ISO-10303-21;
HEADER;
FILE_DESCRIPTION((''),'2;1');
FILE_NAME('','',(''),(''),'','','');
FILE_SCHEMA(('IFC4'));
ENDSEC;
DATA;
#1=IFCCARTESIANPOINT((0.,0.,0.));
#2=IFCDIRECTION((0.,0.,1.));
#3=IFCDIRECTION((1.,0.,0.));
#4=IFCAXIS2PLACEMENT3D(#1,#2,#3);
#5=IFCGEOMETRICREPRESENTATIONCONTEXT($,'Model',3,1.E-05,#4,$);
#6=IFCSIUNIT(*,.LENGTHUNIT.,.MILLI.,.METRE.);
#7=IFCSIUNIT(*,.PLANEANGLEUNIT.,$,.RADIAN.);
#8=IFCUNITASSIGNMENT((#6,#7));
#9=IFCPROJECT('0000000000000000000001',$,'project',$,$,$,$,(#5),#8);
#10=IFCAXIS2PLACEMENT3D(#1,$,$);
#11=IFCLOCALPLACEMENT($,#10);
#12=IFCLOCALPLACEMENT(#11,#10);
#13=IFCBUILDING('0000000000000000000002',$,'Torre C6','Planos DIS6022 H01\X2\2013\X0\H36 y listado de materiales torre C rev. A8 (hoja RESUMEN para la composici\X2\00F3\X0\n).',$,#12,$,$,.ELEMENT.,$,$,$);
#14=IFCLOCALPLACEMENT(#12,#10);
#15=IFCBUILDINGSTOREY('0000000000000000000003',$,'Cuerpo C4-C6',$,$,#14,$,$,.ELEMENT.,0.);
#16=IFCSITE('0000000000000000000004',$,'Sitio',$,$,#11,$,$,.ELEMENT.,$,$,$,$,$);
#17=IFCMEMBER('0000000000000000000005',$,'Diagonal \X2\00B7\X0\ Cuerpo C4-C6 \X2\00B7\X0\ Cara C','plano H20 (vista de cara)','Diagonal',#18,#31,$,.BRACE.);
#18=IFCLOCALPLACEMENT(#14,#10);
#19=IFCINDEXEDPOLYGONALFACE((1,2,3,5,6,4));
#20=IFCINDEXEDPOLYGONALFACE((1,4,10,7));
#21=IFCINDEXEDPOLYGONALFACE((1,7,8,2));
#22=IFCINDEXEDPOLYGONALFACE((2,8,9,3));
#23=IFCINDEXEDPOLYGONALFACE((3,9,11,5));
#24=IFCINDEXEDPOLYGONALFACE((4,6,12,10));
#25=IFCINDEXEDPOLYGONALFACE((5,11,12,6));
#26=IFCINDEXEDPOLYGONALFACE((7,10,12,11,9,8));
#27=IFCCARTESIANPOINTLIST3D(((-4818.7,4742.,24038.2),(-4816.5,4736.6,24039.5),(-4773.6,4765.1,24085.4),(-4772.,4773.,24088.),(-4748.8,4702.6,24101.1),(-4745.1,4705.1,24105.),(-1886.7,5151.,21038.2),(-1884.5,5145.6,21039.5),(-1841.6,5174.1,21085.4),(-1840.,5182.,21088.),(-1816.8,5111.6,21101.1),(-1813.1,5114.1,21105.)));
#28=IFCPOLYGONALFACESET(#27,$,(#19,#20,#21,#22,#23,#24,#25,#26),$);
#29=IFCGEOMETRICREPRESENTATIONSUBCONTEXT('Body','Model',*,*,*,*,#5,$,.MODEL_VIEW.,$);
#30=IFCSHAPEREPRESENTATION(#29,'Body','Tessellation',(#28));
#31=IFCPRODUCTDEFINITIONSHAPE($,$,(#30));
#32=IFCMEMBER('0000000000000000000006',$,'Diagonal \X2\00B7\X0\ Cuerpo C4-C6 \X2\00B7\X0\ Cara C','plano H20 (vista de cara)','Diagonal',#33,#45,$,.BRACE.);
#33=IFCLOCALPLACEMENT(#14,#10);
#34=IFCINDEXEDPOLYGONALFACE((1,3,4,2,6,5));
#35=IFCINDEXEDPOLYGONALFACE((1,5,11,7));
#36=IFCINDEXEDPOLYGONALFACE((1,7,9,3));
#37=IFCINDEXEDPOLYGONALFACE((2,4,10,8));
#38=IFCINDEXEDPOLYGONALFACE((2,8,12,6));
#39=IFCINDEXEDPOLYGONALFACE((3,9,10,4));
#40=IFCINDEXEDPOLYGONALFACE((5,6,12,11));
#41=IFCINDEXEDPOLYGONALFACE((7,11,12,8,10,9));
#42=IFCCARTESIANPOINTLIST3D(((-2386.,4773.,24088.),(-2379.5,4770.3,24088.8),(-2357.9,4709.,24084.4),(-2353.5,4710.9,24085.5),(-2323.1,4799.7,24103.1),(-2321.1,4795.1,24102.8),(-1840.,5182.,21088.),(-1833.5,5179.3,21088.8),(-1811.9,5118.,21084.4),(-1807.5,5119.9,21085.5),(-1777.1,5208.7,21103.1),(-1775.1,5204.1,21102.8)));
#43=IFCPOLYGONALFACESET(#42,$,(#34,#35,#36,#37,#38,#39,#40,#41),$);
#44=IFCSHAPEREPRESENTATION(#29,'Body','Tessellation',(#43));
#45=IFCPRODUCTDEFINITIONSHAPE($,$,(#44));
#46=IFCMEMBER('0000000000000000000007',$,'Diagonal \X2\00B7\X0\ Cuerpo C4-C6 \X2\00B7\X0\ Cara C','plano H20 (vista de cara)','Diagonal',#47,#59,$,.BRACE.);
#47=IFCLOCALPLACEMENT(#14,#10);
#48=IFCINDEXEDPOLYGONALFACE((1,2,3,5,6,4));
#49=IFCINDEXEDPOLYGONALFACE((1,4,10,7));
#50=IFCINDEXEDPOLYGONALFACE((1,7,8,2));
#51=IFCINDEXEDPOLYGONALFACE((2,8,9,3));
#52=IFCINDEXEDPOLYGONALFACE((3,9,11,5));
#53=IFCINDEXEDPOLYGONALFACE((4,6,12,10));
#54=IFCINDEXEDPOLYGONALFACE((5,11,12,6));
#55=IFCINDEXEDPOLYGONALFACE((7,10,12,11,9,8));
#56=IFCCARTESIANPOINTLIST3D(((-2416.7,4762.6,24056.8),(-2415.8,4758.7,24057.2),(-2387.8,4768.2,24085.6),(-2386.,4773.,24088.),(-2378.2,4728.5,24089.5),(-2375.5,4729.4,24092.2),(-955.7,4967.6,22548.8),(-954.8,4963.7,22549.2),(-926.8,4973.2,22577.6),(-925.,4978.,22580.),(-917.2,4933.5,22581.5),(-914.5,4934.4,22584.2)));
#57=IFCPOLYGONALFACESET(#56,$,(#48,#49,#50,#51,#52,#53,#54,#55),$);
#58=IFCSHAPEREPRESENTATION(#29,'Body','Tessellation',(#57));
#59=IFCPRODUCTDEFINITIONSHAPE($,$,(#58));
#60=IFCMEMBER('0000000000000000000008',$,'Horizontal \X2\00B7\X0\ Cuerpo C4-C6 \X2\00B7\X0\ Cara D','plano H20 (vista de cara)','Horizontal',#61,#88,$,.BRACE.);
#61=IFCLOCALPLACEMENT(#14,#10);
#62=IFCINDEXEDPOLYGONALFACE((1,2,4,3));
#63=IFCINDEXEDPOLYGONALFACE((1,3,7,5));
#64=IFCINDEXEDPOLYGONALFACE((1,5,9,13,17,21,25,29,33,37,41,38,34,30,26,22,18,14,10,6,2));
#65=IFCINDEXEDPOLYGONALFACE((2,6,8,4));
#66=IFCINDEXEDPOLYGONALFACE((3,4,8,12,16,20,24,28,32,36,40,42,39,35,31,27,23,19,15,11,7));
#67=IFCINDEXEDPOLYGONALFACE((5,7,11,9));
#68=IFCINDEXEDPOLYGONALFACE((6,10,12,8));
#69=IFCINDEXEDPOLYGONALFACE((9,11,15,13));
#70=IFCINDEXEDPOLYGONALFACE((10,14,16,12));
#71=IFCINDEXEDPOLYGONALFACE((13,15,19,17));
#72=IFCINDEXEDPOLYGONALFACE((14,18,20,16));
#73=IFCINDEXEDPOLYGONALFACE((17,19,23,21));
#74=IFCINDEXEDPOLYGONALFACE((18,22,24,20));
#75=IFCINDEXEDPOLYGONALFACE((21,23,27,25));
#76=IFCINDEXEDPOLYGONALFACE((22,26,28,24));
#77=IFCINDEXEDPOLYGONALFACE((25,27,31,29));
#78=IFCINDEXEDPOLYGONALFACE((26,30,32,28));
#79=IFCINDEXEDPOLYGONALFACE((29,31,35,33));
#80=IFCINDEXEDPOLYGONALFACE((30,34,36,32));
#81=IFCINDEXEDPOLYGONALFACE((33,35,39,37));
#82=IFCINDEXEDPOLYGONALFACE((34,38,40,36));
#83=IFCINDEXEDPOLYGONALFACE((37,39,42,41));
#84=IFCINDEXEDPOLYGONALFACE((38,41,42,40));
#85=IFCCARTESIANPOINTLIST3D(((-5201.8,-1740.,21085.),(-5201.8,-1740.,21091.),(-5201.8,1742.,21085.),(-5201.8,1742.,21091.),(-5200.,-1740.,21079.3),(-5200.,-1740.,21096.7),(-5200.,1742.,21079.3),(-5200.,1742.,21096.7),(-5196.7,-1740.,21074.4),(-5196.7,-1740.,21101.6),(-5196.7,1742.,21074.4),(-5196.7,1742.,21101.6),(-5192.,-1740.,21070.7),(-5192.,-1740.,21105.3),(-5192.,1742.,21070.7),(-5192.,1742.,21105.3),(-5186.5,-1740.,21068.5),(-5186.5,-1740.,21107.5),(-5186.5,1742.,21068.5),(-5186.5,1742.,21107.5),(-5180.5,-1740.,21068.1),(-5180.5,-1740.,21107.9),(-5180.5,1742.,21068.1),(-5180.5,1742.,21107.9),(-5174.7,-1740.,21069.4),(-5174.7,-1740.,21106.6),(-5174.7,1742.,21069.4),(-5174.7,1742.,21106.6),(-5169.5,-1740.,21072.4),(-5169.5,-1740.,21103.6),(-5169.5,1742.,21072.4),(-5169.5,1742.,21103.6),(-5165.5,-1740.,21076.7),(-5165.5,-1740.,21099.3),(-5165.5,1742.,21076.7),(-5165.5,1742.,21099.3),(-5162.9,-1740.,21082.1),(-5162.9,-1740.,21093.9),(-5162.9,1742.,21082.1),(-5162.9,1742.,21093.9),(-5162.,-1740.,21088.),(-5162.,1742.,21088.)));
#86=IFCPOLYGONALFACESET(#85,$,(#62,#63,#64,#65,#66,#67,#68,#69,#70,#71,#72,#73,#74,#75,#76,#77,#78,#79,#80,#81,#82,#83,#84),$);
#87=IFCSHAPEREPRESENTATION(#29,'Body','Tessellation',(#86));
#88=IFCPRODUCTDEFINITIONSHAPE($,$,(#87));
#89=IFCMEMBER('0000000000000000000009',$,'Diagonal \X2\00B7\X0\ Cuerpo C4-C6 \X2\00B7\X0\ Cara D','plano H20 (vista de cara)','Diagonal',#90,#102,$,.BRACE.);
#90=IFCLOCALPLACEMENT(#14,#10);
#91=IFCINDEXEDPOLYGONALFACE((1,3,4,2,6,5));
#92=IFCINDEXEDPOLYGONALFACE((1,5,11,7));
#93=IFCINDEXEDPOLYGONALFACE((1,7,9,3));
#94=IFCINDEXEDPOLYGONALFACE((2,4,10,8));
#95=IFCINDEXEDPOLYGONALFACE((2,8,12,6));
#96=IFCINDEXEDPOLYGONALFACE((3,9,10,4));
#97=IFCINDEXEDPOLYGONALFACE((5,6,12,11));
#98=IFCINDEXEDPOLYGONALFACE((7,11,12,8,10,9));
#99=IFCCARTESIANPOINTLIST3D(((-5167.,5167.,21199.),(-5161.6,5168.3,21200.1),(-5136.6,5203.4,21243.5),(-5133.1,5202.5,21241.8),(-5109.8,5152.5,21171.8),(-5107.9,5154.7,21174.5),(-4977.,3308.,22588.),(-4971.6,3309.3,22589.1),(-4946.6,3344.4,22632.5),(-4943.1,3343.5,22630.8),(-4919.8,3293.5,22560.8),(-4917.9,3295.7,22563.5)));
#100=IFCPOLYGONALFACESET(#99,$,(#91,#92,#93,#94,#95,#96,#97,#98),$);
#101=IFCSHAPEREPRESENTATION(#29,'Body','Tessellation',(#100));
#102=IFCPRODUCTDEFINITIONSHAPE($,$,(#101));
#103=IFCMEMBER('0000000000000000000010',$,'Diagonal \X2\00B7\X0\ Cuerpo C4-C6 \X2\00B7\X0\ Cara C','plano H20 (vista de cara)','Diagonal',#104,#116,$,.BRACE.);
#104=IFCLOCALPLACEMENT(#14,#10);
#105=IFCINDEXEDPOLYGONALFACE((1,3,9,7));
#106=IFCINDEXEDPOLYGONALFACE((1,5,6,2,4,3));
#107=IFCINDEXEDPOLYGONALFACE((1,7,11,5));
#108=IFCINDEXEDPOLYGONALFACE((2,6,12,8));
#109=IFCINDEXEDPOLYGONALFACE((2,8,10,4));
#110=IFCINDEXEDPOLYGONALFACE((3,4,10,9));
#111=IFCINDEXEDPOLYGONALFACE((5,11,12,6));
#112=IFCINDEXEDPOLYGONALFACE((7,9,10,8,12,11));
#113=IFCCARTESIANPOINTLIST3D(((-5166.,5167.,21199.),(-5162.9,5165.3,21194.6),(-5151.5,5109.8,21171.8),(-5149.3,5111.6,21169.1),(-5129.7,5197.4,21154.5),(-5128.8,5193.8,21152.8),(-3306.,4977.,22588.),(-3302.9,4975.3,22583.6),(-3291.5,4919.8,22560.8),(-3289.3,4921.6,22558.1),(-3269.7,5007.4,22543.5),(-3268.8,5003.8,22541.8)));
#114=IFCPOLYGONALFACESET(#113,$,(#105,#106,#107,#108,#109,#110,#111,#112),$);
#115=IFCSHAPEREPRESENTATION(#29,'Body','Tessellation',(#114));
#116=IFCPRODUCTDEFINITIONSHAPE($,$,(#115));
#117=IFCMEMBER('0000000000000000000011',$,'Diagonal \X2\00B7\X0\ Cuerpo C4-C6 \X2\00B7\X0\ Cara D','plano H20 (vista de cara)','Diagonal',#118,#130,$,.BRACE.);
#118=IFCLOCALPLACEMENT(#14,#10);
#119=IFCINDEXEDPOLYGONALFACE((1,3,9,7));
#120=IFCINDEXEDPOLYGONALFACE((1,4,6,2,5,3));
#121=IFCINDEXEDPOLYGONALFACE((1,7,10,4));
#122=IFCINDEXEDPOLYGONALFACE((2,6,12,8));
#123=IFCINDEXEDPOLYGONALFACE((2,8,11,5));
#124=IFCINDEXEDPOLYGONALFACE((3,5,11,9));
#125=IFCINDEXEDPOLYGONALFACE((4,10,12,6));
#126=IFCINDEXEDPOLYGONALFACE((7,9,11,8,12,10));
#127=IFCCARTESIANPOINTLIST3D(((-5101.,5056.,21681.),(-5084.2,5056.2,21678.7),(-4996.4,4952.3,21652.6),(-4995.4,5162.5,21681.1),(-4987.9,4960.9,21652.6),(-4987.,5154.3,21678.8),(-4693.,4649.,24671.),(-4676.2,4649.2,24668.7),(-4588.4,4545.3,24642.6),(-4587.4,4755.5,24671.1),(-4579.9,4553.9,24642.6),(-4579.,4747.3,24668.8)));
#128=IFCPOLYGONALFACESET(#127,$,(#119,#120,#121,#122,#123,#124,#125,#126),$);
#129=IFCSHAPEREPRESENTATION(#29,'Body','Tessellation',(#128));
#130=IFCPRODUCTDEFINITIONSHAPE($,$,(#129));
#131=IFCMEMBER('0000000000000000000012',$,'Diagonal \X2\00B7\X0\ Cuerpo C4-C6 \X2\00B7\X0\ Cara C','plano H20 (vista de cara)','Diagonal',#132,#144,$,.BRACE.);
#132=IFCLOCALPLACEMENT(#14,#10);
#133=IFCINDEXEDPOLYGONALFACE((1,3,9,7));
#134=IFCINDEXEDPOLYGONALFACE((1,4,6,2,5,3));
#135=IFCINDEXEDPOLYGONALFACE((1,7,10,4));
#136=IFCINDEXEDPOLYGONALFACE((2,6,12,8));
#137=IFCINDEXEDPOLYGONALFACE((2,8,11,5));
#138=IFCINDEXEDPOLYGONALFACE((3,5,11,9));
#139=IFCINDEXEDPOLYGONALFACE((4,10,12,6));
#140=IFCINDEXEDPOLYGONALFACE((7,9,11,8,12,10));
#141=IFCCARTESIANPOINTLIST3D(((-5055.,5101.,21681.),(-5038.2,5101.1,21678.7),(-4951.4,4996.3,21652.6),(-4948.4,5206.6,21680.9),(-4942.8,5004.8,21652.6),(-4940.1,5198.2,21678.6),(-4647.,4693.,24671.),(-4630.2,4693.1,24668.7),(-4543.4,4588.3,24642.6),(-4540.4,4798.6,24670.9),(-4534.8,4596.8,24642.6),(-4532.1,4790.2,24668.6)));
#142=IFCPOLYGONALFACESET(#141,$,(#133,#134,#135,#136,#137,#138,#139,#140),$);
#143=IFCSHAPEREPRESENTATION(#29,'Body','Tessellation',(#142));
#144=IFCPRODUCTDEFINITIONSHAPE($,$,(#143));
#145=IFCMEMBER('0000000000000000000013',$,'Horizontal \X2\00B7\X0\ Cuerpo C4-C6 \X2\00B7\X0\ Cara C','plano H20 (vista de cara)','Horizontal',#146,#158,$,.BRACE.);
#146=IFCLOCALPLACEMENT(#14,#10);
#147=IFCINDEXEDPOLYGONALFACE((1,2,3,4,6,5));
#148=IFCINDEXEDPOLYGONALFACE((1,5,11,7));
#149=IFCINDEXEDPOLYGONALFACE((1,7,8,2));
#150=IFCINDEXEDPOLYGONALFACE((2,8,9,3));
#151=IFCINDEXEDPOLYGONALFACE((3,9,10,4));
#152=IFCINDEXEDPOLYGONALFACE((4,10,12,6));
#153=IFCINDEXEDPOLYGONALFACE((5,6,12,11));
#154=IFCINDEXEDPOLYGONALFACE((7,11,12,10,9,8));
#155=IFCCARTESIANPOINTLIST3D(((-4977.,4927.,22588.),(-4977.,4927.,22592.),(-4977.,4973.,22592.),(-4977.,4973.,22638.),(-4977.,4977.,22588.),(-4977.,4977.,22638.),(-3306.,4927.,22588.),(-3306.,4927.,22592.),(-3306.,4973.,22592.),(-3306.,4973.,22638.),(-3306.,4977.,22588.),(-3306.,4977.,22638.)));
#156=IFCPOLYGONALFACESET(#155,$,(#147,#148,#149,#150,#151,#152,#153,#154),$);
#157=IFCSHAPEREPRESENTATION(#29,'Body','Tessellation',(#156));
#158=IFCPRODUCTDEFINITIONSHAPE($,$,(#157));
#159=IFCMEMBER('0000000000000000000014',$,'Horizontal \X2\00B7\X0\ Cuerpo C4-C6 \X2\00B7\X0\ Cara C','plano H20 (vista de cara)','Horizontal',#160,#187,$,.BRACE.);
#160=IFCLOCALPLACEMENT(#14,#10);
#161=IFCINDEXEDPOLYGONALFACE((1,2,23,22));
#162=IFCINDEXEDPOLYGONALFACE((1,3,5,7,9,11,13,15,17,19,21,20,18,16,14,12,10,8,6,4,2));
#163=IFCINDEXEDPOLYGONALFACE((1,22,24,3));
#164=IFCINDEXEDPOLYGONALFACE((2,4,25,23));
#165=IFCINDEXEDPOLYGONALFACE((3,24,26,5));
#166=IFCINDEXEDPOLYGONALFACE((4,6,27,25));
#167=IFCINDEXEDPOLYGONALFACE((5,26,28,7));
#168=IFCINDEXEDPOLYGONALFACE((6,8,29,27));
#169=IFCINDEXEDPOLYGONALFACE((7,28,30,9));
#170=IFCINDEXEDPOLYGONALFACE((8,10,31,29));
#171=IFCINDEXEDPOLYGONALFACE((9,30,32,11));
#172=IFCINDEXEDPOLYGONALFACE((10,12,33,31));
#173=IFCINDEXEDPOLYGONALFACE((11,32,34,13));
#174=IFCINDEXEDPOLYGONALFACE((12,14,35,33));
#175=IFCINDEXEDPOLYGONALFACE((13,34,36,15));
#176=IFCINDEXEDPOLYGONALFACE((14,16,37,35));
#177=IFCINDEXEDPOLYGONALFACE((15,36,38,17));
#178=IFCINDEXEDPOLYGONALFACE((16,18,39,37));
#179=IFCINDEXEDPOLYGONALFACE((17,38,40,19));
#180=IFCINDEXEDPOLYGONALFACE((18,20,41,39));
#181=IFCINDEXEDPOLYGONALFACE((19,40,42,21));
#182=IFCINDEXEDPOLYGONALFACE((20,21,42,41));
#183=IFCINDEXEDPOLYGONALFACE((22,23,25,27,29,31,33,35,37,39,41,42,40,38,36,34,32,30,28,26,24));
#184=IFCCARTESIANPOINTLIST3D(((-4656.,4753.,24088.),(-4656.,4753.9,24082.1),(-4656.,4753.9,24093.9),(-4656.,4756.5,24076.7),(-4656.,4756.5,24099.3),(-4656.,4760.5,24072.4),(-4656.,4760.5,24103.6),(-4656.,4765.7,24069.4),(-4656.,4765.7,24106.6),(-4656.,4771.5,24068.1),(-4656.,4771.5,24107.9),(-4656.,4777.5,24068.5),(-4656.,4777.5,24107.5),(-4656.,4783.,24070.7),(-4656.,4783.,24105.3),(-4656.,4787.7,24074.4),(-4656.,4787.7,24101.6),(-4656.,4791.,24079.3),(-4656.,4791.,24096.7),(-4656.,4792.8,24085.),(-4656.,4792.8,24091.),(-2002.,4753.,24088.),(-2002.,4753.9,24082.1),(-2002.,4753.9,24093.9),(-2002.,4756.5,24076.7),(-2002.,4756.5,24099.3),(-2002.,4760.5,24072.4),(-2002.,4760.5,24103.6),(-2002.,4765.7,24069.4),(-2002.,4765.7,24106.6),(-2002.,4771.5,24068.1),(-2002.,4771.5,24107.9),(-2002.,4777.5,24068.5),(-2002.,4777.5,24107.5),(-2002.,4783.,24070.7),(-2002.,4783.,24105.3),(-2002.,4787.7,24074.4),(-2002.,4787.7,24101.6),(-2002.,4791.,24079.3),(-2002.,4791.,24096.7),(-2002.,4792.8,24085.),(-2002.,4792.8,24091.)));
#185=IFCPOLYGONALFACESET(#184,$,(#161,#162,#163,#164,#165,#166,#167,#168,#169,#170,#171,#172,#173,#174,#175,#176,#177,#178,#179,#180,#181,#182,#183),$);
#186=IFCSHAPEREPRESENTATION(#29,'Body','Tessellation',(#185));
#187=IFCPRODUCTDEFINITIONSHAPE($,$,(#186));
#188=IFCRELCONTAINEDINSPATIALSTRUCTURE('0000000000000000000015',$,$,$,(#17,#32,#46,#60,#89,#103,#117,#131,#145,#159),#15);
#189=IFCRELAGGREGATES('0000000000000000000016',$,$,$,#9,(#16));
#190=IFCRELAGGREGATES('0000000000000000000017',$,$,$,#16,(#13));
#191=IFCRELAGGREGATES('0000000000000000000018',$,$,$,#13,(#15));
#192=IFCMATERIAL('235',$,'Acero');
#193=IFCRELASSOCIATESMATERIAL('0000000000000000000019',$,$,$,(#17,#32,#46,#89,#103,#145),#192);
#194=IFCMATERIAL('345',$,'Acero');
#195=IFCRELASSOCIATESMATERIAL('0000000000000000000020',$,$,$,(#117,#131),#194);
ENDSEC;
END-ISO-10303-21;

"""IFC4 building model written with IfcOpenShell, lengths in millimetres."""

from ifc_helpers import new_model, si_unit, frame, frame_2d, origin, origin_with_axes, place, context, subcontext, project, spatial, circle, l_section, extrude, material, element, save


model = new_model("IFC4")

# Units and contexts
model_context = context("Model", 3, precision=1e-05, world=origin_with_axes())
body_context = subcontext(model_context, "Body", "Model", "MODEL_VIEW")
ifc_project = project(units=[si_unit("LENGTHUNIT", "METRE", prefix="MILLI"), si_unit("PLANEANGLEUNIT", "RADIAN")], contexts=[model_context])

# Site, building, storey
site_placement = place(None, origin())
site = spatial("IfcSite", under=ifc_project, at=site_placement, Name="Sitio", CompositionType="ELEMENT")
building_placement = place(site_placement, origin())
building = spatial("IfcBuilding", under=site, at=building_placement, Name="Torre C6", Description="Planos DIS6022 H01–H36 y listado de materiales torre C rev. A8 (hoja RESUMEN para la composición).", CompositionType="ELEMENT")
storey_placement = place(building_placement, origin())
storey = spatial("IfcBuildingStorey", under=building, at=storey_placement, Name="Cuerpo C4-C6", CompositionType="ELEMENT", Elevation=0.0)

# Members
ifc_material_1 = material(Name="235", Category="Acero")
member_1_placement = place(storey_placement, frame((-4772.0, 4773.0, 24088.0), z_axis=(0.695656, 0.097041, -0.71179), x_axis=(0.35874, -0.905371, 0.227176)))
element("IfcMember", 1, at=member_1_placement, inside=storey, material=ifc_material_1, Name="Diagonal · Cuerpo C4-C6 · Cara C", Description="plano H20 (vista de cara)", ObjectType="Diagonal", PredefinedType="BRACE", context=body_context, shape_type="SweptSolid", body=[
    extrude(l_section(Depth=75.0, Width=75.0, Thickness=6.0, at=frame_2d((37.5, 37.5))), None, (0.0, 0.0, 1.0), 4214.7),
])
member_2_placement = place(storey_placement, frame((-1840.0, 5182.0, 21088.0), z_axis=(-0.177469, -0.132939, 0.975106), x_axis=(0.400732, -0.914731, -0.051775)))
element("IfcMember", 2, at=member_2_placement, inside=storey, material=ifc_material_1, Name="Diagonal · Cuerpo C4-C6 · Cara C", Description="plano H20 (vista de cara)", ObjectType="Diagonal", PredefinedType="BRACE", context=body_context, shape_type="SweptSolid", body=[
    extrude(l_section(Depth=70.0, Width=70.0, Thickness=5.0, at=frame_2d((35.0, 35.0))), None, (0.0, 0.0, 1.0), 3076.6),
])
member_3_placement = place(storey_placement, frame((-2386.0, 4773.0, 24088.0), z_axis=(0.692533, 0.097173, -0.714812), x_axis=(0.233041, -0.967894, 0.0942)))
element("IfcMember", 3, at=member_3_placement, inside=storey, material=ifc_material_1, Name="Diagonal · Cuerpo C4-C6 · Cara C", Description="plano H20 (vista de cara)", ObjectType="Diagonal", PredefinedType="BRACE", context=body_context, shape_type="SweptSolid", body=[
    extrude(l_section(Depth=45.0, Width=45.0, Thickness=4.0, at=frame_2d((22.5, 22.5))), None, (0.0, 0.0, 1.0), 2109.6),
])
member_4_placement = place(storey_placement, frame((-5182.0, 1742.0, 21088.0), z_axis=(0.0, -1.0, 0.0), x_axis=(1.0, 0.0, 0.0)))
element("IfcMember", 4, at=member_4_placement, inside=storey, Name="Horizontal · Cuerpo C4-C6 · Cara D", Description="plano H20 (vista de cara)", ObjectType="Horizontal", PredefinedType="BRACE", context=body_context, shape_type="SweptSolid", body=[
    extrude(circle(Radius=20.0), None, (0.0, 0.0, 1.0), 3482.0),
])
member_5_placement = place(storey_placement, frame((-5167.0, 5167.0, 21199.0), z_axis=(0.081602, -0.798413, 0.596555), x_axis=(0.880323, -0.222902, -0.418744)))
element("IfcMember", 5, at=member_5_placement, inside=storey, material=ifc_material_1, Name="Diagonal · Cuerpo C4-C6 · Cara D", Description="plano H20 (vista de cara)", ObjectType="Diagonal", PredefinedType="BRACE", context=body_context, shape_type="SweptSolid", body=[
    extrude(l_section(Depth=65.0, Width=65.0, Thickness=4.0, at=frame_2d((32.5, 32.5))), None, (0.0, 0.0, 1.0), 2328.4),
])
member_6_placement = place(storey_placement, frame((-5166.0, 5167.0, 21199.0), z_axis=(0.798569, -0.081574, 0.59635), x_axis=(0.222644, -0.880466, -0.41858)))
element("IfcMember", 6, at=member_6_placement, inside=storey, material=ifc_material_1, Name="Diagonal · Cuerpo C4-C6 · Cara C", Description="plano H20 (vista de cara)", ObjectType="Diagonal", PredefinedType="BRACE", context=body_context, shape_type="SweptSolid", body=[
    extrude(l_section(Depth=65.0, Width=65.0, Thickness=4.0, at=frame_2d((32.5, 32.5))), None, (0.0, 0.0, 1.0), 2329.2),
])
ifc_material_2 = material(Name="345", Category="Acero")
member_7_placement = place(storey_placement, frame((-5101.0, 5056.0, 21681.0), z_axis=(0.133989, -0.13366, 0.981928), x_axis=(0.697575, -0.691065, -0.189256)))
element("IfcMember", 7, at=member_7_placement, inside=storey, material=ifc_material_2, Name="Diagonal · Cuerpo C4-C6 · Cara D", Description="plano H20 (vista de cara)", ObjectType="Diagonal", PredefinedType="BRACE", context=body_context, shape_type="SweptSolid", body=[
    extrude(l_section(Depth=150.0, Width=150.0, Thickness=12.0, at=frame_2d((75.0, 75.0))), None, (0.0, 0.0, 1.0), 3045.0),
])
member_8_placement = place(storey_placement, frame((-5055.0, 5101.0, 21681.0), z_axis=(0.133983, -0.133983, 0.981884), x_axis=(0.690891, -0.697687, -0.189478)))
element("IfcMember", 8, at=member_8_placement, inside=storey, material=ifc_material_2, Name="Diagonal · Cuerpo C4-C6 · Cara C", Description="plano H20 (vista de cara)", ObjectType="Diagonal", PredefinedType="BRACE", context=body_context, shape_type="SweptSolid", body=[
    extrude(l_section(Depth=150.0, Width=150.0, Thickness=12.0, at=frame_2d((75.0, 75.0))), None, (0.0, 0.0, 1.0), 3045.2),
])
member_9_placement = place(storey_placement, frame((-3306.0, 4977.0, 22588.0), z_axis=(-1.0, 0.0, 0.0), x_axis=(0.0, -1.0, 0.0)))
element("IfcMember", 9, at=member_9_placement, inside=storey, material=ifc_material_1, Name="Horizontal · Cuerpo C4-C6 · Cara C", Description="plano H20 (vista de cara)", ObjectType="Horizontal", PredefinedType="BRACE", context=body_context, shape_type="SweptSolid", body=[
    extrude(l_section(Depth=50.0, Width=50.0, Thickness=4.0, at=frame_2d((25.0, 25.0))), None, (0.0, 0.0, 1.0), 1671.0),
])
member_10_placement = place(storey_placement, frame((-4656.0, 4773.0, 24088.0), z_axis=(1.0, 0.0, 0.0), x_axis=(0.0, -1.0, 0.0)))
element("IfcMember", 10, at=member_10_placement, inside=storey, Name="Horizontal · Cuerpo C4-C6 · Cara C", Description="plano H20 (vista de cara)", ObjectType="Horizontal", PredefinedType="BRACE", context=body_context, shape_type="SweptSolid", body=[
    extrude(circle(Radius=20.0), None, (0.0, 0.0, 1.0), 2654.0),
])

save(model, "model.ifc")
